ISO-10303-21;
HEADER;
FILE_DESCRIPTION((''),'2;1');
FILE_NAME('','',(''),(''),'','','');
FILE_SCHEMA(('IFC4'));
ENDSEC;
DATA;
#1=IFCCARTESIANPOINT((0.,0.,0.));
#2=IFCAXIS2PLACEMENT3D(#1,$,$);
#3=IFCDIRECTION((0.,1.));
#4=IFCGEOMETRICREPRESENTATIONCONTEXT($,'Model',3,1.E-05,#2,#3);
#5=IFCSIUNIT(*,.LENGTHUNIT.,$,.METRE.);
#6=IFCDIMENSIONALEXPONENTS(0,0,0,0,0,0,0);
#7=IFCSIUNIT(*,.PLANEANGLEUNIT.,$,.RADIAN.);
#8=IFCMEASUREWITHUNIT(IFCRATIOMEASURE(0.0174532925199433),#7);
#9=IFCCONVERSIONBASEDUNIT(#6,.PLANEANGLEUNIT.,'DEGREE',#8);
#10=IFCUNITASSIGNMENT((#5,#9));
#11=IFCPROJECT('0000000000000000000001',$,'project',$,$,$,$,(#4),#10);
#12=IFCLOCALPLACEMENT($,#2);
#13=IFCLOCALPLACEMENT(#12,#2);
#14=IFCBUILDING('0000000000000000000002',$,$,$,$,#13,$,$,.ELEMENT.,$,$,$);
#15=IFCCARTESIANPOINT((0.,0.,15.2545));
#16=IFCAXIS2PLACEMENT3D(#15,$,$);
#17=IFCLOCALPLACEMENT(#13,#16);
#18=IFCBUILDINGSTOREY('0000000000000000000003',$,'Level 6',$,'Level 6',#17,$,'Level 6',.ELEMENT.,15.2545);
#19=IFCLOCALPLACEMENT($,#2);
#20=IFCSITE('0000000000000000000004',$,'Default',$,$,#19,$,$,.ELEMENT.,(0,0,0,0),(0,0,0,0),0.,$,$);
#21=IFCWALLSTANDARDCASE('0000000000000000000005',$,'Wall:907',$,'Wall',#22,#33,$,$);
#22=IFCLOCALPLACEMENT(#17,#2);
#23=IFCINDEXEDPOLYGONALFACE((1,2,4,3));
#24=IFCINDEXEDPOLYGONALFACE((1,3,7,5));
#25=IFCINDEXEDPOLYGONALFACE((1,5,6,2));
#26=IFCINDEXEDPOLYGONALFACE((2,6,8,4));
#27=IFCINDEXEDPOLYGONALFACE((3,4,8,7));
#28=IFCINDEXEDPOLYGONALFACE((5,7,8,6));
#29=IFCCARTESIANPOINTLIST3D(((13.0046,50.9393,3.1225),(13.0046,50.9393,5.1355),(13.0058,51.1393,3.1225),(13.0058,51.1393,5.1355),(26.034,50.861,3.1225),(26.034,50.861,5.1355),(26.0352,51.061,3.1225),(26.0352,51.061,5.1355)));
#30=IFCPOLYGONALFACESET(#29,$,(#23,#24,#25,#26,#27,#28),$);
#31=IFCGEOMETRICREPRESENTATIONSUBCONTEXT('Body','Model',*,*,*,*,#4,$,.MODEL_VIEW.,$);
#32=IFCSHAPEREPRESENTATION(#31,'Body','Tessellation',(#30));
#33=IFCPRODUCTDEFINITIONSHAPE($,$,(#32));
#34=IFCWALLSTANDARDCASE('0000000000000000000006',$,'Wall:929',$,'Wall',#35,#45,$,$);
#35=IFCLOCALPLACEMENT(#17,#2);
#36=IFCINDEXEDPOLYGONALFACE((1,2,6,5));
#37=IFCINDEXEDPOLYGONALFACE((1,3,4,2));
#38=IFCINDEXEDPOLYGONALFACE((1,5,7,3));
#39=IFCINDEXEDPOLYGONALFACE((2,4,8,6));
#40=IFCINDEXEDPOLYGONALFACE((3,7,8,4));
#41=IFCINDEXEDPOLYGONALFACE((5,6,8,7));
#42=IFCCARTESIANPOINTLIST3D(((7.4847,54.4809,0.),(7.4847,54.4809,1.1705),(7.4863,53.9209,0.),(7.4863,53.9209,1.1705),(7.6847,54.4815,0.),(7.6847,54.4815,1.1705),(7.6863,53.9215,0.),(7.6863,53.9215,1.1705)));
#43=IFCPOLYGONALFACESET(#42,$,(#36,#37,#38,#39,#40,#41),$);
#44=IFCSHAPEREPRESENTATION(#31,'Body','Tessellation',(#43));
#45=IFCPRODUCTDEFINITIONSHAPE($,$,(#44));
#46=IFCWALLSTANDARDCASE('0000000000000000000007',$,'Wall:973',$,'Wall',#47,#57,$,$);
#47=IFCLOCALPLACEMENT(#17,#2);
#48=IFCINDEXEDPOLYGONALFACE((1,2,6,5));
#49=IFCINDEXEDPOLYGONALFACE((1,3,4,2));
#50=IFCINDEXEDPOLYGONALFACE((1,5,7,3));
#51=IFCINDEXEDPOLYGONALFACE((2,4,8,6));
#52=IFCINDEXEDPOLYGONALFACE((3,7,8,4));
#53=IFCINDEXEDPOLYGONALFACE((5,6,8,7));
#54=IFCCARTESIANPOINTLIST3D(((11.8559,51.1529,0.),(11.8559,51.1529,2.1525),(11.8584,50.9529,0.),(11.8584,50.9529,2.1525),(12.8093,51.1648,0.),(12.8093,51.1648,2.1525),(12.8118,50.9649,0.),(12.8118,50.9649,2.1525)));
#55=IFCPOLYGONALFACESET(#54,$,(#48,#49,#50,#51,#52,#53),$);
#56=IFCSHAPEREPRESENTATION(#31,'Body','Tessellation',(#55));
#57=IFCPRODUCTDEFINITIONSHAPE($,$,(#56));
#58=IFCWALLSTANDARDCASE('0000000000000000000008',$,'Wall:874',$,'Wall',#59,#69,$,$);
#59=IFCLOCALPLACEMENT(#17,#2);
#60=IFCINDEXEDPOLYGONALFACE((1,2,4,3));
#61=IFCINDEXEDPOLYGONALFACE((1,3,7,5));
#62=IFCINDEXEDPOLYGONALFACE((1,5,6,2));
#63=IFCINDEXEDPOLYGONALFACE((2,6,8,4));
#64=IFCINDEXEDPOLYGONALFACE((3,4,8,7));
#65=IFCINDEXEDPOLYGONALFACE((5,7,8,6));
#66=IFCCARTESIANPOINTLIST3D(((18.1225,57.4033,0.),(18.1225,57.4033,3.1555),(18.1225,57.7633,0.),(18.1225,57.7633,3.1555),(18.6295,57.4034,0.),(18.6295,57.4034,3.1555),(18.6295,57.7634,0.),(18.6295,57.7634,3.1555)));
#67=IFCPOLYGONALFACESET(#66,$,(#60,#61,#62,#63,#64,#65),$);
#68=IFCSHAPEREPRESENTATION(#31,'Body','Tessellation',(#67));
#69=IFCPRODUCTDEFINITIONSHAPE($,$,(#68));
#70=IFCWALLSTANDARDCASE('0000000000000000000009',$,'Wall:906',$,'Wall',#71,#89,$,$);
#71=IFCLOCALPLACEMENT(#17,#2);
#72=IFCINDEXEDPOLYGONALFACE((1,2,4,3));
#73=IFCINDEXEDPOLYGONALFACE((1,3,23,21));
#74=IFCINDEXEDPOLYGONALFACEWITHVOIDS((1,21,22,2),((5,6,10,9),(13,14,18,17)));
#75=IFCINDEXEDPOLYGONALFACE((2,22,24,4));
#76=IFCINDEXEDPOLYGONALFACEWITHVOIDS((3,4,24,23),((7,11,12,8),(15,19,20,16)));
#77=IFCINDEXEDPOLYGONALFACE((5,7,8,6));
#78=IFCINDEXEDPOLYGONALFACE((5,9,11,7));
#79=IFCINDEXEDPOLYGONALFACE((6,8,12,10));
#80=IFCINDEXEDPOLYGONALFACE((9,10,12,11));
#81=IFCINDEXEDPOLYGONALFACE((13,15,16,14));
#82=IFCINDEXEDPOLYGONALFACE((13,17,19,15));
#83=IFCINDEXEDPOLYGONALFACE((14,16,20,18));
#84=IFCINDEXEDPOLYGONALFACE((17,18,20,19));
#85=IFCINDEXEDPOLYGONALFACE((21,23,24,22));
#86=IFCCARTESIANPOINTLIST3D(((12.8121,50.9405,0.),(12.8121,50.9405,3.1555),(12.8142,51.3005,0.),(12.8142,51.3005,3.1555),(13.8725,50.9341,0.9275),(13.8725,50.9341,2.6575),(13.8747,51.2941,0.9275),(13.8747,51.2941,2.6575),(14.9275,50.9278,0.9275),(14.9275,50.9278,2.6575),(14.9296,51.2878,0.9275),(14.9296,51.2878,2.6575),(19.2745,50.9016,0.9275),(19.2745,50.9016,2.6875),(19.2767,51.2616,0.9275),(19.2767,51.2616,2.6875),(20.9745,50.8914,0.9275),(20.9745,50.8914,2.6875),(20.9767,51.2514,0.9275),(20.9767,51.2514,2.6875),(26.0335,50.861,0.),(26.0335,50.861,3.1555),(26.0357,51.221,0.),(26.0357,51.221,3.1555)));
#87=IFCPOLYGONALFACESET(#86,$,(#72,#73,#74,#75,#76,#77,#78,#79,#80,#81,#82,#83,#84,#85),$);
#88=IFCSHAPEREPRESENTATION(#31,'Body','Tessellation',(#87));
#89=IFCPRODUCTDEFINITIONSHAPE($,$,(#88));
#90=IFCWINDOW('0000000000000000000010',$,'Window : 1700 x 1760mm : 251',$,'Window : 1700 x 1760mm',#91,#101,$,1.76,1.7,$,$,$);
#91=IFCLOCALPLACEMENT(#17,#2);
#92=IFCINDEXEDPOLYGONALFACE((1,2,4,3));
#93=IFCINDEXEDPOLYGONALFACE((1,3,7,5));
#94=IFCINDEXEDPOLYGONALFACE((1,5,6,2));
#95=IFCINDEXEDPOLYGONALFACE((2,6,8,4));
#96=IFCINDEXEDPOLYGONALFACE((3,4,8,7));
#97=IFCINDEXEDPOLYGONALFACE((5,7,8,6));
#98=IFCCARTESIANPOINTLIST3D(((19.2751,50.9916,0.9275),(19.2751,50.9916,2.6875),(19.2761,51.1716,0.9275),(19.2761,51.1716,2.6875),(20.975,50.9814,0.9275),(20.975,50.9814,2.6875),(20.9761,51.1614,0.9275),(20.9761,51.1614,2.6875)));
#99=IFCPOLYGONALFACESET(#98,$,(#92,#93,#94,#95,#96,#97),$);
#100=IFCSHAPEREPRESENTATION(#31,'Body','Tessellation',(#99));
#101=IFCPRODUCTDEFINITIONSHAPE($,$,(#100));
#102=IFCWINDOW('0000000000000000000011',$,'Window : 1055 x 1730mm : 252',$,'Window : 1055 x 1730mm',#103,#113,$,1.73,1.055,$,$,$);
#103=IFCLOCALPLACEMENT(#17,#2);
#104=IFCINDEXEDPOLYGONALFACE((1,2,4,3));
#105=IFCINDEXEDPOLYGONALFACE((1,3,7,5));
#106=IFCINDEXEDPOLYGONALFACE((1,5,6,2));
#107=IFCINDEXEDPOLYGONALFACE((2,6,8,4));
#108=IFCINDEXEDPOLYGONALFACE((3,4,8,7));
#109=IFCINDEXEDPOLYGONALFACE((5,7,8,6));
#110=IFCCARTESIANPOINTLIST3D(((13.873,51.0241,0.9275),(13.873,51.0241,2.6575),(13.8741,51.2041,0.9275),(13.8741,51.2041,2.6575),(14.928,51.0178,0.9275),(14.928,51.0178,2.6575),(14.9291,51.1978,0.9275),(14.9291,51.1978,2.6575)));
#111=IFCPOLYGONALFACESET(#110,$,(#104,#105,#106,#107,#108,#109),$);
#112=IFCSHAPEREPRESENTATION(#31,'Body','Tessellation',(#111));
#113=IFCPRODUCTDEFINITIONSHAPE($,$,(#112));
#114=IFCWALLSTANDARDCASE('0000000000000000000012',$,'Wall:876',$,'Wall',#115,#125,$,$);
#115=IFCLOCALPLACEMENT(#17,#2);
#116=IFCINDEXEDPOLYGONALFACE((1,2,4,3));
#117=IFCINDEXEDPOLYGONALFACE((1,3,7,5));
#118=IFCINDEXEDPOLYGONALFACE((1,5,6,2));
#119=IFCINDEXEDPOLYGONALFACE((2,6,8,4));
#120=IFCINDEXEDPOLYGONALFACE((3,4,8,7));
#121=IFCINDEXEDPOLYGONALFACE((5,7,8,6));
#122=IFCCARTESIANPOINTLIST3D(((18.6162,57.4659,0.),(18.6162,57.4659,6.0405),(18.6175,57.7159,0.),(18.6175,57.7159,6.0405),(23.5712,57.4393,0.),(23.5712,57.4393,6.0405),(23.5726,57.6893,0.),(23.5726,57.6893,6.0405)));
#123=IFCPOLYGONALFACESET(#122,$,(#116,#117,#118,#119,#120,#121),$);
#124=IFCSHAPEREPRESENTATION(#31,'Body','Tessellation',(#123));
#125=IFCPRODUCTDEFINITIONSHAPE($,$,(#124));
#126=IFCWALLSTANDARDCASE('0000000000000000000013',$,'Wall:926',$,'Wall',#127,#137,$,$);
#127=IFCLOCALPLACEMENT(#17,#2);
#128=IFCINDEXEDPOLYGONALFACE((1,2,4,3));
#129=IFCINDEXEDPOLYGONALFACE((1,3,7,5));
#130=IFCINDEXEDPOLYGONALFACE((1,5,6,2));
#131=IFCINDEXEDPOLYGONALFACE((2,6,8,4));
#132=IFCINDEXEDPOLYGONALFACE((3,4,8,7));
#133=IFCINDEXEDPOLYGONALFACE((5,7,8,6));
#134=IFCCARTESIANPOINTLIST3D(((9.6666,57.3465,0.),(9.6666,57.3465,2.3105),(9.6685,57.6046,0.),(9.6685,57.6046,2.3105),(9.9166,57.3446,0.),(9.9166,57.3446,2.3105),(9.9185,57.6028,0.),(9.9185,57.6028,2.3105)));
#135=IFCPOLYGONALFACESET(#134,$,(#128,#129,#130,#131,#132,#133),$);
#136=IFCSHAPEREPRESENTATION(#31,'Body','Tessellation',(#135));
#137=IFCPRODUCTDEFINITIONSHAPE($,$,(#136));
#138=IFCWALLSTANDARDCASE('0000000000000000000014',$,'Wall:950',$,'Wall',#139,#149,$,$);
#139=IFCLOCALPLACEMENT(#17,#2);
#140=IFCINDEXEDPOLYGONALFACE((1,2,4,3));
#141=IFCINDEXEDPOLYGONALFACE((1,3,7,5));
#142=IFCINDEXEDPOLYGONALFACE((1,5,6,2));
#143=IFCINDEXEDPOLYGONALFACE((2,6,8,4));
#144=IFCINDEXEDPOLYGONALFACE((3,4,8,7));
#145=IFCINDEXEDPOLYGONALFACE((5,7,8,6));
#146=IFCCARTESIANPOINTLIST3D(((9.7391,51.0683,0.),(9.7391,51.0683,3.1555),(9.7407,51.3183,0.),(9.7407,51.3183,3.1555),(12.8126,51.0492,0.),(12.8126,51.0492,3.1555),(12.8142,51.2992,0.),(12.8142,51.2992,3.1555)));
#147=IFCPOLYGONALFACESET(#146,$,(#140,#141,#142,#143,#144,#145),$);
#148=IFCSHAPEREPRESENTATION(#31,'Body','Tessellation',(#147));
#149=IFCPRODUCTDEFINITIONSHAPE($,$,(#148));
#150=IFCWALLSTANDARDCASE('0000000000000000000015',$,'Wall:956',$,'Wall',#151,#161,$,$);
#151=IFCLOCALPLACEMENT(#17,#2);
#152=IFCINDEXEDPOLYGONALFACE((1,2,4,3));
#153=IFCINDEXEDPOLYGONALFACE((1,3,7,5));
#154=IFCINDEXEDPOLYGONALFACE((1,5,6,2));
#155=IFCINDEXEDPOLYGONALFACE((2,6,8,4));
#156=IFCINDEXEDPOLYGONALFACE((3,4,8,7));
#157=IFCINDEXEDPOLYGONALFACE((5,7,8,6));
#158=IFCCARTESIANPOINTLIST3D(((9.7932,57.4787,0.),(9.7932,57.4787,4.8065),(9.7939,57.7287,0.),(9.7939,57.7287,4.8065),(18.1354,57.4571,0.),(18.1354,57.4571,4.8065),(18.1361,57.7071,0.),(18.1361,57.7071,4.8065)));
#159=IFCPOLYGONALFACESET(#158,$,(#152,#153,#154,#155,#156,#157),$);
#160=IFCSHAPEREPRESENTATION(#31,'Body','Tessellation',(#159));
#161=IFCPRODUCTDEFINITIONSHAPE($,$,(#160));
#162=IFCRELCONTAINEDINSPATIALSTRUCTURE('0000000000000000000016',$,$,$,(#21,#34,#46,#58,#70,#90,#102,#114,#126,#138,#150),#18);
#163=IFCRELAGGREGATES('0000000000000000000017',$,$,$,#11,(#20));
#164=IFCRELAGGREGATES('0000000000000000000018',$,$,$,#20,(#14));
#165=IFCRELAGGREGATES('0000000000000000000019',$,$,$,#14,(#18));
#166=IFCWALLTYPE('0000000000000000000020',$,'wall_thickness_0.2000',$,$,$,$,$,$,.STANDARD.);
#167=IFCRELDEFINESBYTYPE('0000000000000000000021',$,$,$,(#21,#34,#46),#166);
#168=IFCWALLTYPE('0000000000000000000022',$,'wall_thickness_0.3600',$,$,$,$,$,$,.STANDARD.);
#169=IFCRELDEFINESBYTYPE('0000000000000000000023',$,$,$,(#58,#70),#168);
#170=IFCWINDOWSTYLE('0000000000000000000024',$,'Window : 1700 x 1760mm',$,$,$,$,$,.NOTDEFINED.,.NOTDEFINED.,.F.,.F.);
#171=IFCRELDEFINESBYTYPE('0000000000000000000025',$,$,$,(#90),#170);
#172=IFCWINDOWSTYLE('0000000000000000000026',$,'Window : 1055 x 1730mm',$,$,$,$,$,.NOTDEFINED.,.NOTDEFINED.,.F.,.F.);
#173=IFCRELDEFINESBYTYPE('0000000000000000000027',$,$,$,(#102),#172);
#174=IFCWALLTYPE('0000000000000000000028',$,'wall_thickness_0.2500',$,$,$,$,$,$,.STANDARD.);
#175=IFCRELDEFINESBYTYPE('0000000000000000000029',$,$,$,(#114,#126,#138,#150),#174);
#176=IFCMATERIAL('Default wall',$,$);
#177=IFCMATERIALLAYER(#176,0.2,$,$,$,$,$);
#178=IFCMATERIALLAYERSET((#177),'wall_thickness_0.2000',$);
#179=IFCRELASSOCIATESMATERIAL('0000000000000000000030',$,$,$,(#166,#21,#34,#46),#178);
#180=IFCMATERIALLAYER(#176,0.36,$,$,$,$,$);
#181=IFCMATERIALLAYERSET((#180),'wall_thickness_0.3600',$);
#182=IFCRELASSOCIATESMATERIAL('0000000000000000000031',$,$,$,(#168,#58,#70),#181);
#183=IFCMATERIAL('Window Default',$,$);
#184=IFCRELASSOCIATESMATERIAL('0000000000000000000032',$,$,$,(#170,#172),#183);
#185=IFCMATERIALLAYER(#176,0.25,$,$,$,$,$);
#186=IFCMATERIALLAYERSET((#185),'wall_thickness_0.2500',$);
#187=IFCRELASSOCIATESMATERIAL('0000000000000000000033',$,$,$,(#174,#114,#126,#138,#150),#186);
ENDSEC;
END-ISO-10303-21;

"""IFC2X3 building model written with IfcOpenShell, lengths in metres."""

from ifc_helpers import new_model, entity, si_unit, converted_unit, direction, frame, frame_2d, origin, origin_2d_with_axis, place, context, subcontext, project, spatial, polyline, rectangle, outline, extrude, source, transform, mapped, material, layer, layer_set, layer_usage, type_object, type_shapes, element, fill, save


model = new_model("IFC2X3")

# Units and contexts
model_context = context("Model", 3, precision=1e-05, world=origin(), true_north=direction((0.0, 1.0)))
body_context = subcontext(model_context, "Body", "Model", "MODEL_VIEW")
ifc_project = project(units=[si_unit("LENGTHUNIT", "METRE"), converted_unit("PLANEANGLEUNIT", "DEGREE", entity("IfcRatioMeasure", 0.0174532925199433), si_unit("PLANEANGLEUNIT", "RADIAN"), dimensions=[0, 0, 0, 0, 0, 0, 0])], contexts=[model_context])

# Site, building, storey
site_placement = place(None, origin())
site = spatial("IfcSite", under=ifc_project, at=site_placement, Name="Default", CompositionType="ELEMENT", RefLatitude=(0, 0, 0, 0), RefLongitude=(0, 0, 0, 0), RefElevation=0.0)
placement_1 = place(None, origin())
building_placement = place(placement_1, origin())
building = spatial("IfcBuilding", under=site, at=building_placement, CompositionType="ELEMENT")
storey_placement = place(building_placement, frame((0.0, 0.0, 15.2545)))
storey = spatial("IfcBuildingStorey", under=building, at=storey_placement, Name="Level 6", ObjectType="Level 6", LongName="Level 6", CompositionType="ELEMENT", Elevation=15.2545)

# Shared definitions
ifc_material_1 = material(Name="Default wall")
ifc_material_2 = material(Name="Window Default")

# Walls
ifc_layer_1 = layer(ifc_material_1, 0.2)
ifc_layer_set_1 = layer_set([ifc_layer_1], Name="wall_thickness_0.2000")
ifc_layer_usage_1 = layer_usage(ifc_layer_set_1, "AXIS2", "POSITIVE", -0.1)
wall_type_1 = type_object("IfcWallType", Name="wall_thickness_0.2000", PredefinedType="STANDARD", material=ifc_layer_set_1)
placement_2 = place(building_placement, frame((0.0, 0.0, 18.377)))
wall_1_placement = place(placement_2, frame((13.0052, 51.0393, 0.0), z_axis=(0.0, 0.0, 1.0), x_axis=(0.999982, -0.006009, 0.0)))
element("IfcWallStandardCase", 1, at=wall_1_placement, inside=storey, type_object=wall_type_1, material=ifc_layer_usage_1, Name="Wall:907", ObjectType="Wall", context=body_context, shape_type="SweptSolid", body=[
    extrude(outline(polyline([(13.0296, -0.1), (13.0296, 0.1), (0.0, 0.1), (0.0, -0.1), (13.0296, -0.1)])), origin(), (0.0, 0.0, 1.0), 2.013),
])
wall_2_placement = place(storey_placement, frame((7.5863, 53.9212, 0.0), z_axis=(0.0, 0.0, 1.0), x_axis=(-0.002904, 0.999996, 0.0)))
element("IfcWallStandardCase", 2, at=wall_2_placement, inside=storey, type_object=wall_type_1, material=ifc_layer_usage_1, Name="Wall:929", ObjectType="Wall", context=body_context, shape_type="SweptSolid", body=[
    extrude(outline(polyline([(0.56, -0.1), (0.56, 0.1), (0.0, 0.1), (0.0, -0.1), (0.56, -0.1)])), origin(), (0.0, 0.0, 1.0), 1.1705),
])
wall_3_placement = place(storey_placement, frame((12.8105, 51.0648, 0.0), z_axis=(0.0, 0.0, 1.0), x_axis=(-0.999922, -0.012511, 0.0)))
element("IfcWallStandardCase", 3, at=wall_3_placement, inside=storey, type_object=wall_type_1, material=ifc_layer_usage_1, Name="Wall:973", ObjectType="Wall", context=body_context, shape_type="SweptSolid", body=[
    extrude(outline(polyline([(0.9534, -0.1), (0.9534, 0.1), (0.0, 0.1), (0.0, -0.1), (0.9534, -0.1)])), origin(), (0.0, 0.0, 1.0), 2.1525),
])
ifc_layer_2 = layer(ifc_material_1, 0.36)
ifc_layer_set_2 = layer_set([ifc_layer_2], Name="wall_thickness_0.3600")
ifc_layer_usage_2 = layer_usage(ifc_layer_set_2, "AXIS2", "POSITIVE", -0.18)
wall_type_2 = type_object("IfcWallType", Name="wall_thickness_0.3600", PredefinedType="STANDARD", material=ifc_layer_set_2)
wall_4_placement = place(storey_placement, frame((18.1225, 57.5833, 0.0), z_axis=(0.0, 0.0, 1.0), x_axis=(1.0, 0.000075, 0.0)))
element("IfcWallStandardCase", 4, at=wall_4_placement, inside=storey, type_object=wall_type_2, material=ifc_layer_usage_2, Name="Wall:874", ObjectType="Wall", context=body_context, shape_type="SweptSolid", body=[
    extrude(outline(polyline([(0.507, -0.18), (0.507, 0.18), (0.0, 0.18), (0.0, -0.18), (0.507, -0.18)])), origin(), (0.0, 0.0, 1.0), 3.1555),
])

# Wall, openings, windows
wall_5_placement = place(storey_placement, frame((12.8132, 51.1205, 0.0), z_axis=(0.0, 0.0, 1.0), x_axis=(0.999982, -0.006009, 0.0)))
wall_5 = element("IfcWallStandardCase", 5, at=wall_5_placement, inside=storey, type_object=wall_type_2, material=ifc_layer_usage_2, Name="Wall:906", ObjectType="Wall", context=body_context, shape_type="SweptSolid", body=[
    extrude(outline(polyline([(13.2216, -0.18), (13.2216, 0.18), (0.0, 0.18), (0.0, -0.18), (13.2216, -0.18)])), origin(), (0.0, 0.0, 1.0), 3.1555),
])
opening_1_placement = place(wall_5_placement, frame((6.4626, -0.18, 0.9275)))
opening_1 = element("IfcOpeningElement", 6, at=opening_1_placement, cuts=wall_5, ObjectType="Opening", context=body_context, shape_type="SweptSolid", body=[
    extrude(rectangle(XDim=1.7, YDim=1.76, at=frame_2d((0.88, 0.85), x_axis=(0.0, 1.0))), frame((0.0, 0.0, 0.0), z_axis=(0.0, 1.0, 0.0), x_axis=(0.0, 0.0, 1.0)), (0.0, 0.0, 1.0), 0.36),
])
opening_2_placement = place(wall_5_placement, frame((1.0604, -0.18, 0.9275)))
opening_2 = element("IfcOpeningElement", 7, at=opening_2_placement, cuts=wall_5, ObjectType="Opening", context=body_context, shape_type="SweptSolid", body=[
    extrude(rectangle(XDim=1.055, YDim=1.73, at=frame_2d((0.865, 0.5275), x_axis=(0.0, 1.0))), frame((0.0, 0.0, 0.0), z_axis=(0.0, 1.0, 0.0), x_axis=(0.0, 0.0, 1.0)), (0.0, 0.0, 1.0), 0.36),
])
window_style_1 = type_object("IfcWindowStyle", Name="Window : 1700 x 1760mm", ConstructionType="NOTDEFINED", OperationType="NOTDEFINED", ParameterTakesPrecedence=False, Sizeable=False, material=ifc_material_2)
shared_shape_1 = source(origin(), body_context, "Body", "SweptSolid", [
    extrude(rectangle(XDim=0.18, YDim=1.7, at=origin_2d_with_axis()), frame((0.85, 0.18, 0.0), z_axis=(0.0, 0.0, 1.0), x_axis=(0.0, 1.0, 0.0)), (0.0, 0.0, 1.0), 1.76),
])
type_shapes(window_style_1, [shared_shape_1])
window_1_placement = place(opening_1_placement, origin())
window_1 = element("IfcWindow", 8, at=window_1_placement, inside=storey, type_object=window_style_1, Name="Window : 1700 x 1760mm : 251", ObjectType="Window : 1700 x 1760mm", OverallHeight=1.76, OverallWidth=1.7, context=body_context, shape_type="MappedRepresentation", body=[
    mapped(shared_shape_1, transform((0.0, 0.0, 0.0), scale=1.0)),
])
fill(opening_1, window_1)
window_style_2 = type_object("IfcWindowStyle", Name="Window : 1055 x 1730mm", ConstructionType="NOTDEFINED", OperationType="NOTDEFINED", ParameterTakesPrecedence=False, Sizeable=False, material=ifc_material_2)
shared_shape_2 = source(origin(), body_context, "Body", "SweptSolid", [
    extrude(rectangle(XDim=0.18, YDim=1.055, at=origin_2d_with_axis()), frame((0.5275, 0.18, 0.0), z_axis=(0.0, 0.0, 1.0), x_axis=(0.0, 1.0, 0.0)), (0.0, 0.0, 1.0), 1.73),
])
type_shapes(window_style_2, [shared_shape_2])
window_2_placement = place(opening_2_placement, origin())
window_2 = element("IfcWindow", 9, at=window_2_placement, inside=storey, type_object=window_style_2, Name="Window : 1055 x 1730mm : 252", ObjectType="Window : 1055 x 1730mm", OverallHeight=1.73, OverallWidth=1.055, context=body_context, shape_type="MappedRepresentation", body=[
    mapped(shared_shape_2, transform((0.0, 0.0, 0.0), scale=1.0)),
])
fill(opening_2, window_2)

# Walls
ifc_layer_3 = layer(ifc_material_1, 0.25)
ifc_layer_set_3 = layer_set([ifc_layer_3], Name="wall_thickness_0.2500")
ifc_layer_usage_3 = layer_usage(ifc_layer_set_3, "AXIS2", "POSITIVE", -0.125)
wall_type_3 = type_object("IfcWallType", Name="wall_thickness_0.2500", PredefinedType="STANDARD", material=ifc_layer_set_3)
wall_6_placement = place(storey_placement, frame((18.6168, 57.5909, 0.0), z_axis=(0.0, 0.0, 1.0), x_axis=(0.999986, -0.005371, 0.0)))
element("IfcWallStandardCase", 10, at=wall_6_placement, inside=storey, type_object=wall_type_3, material=ifc_layer_usage_3, Name="Wall:876", ObjectType="Wall", context=body_context, shape_type="SweptSolid", body=[
    extrude(outline(polyline([(4.9551, -0.125), (4.9551, 0.125), (0.0, 0.125), (0.0, -0.125), (4.9551, -0.125)])), origin(), (0.0, 0.0, 1.0), 6.0405),
])
wall_7_placement = place(storey_placement, frame((9.7935, 57.6037, 0.0), z_axis=(0.0, 0.0, 1.0), x_axis=(-0.007478, -0.999972, 0.0)))
element("IfcWallStandardCase", 11, at=wall_7_placement, inside=storey, type_object=wall_type_3, material=ifc_layer_usage_3, Name="Wall:926", ObjectType="Wall", context=body_context, shape_type="SweptSolid", body=[
    extrude(outline(polyline([(0.2581, -0.125), (0.2581, 0.125), (0.0, 0.125), (0.0, -0.125), (0.2581, -0.125)])), origin(), (0.0, 0.0, 1.0), 2.3105),
])
wall_8_placement = place(storey_placement, frame((9.7399, 51.1933, 0.0), z_axis=(0.0, 0.0, 1.0), x_axis=(0.999981, -0.006219, 0.0)))
element("IfcWallStandardCase", 12, at=wall_8_placement, inside=storey, type_object=wall_type_3, material=ifc_layer_usage_3, Name="Wall:950", ObjectType="Wall", context=body_context, shape_type="SweptSolid", body=[
    extrude(outline(polyline([(3.0735, -0.125), (3.0735, 0.125), (0.0, 0.125), (0.0, -0.125), (3.0735, -0.125)])), origin(), (0.0, 0.0, 1.0), 3.1555),
])
wall_9_placement = place(storey_placement, frame((9.7935, 57.6037, 0.0), z_axis=(0.0, 0.0, 1.0), x_axis=(0.999997, -0.002586, 0.0)))
element("IfcWallStandardCase", 13, at=wall_9_placement, inside=storey, type_object=wall_type_3, material=ifc_layer_usage_3, Name="Wall:956", ObjectType="Wall", context=body_context, shape_type="SweptSolid", body=[
    extrude(outline(polyline([(8.3423, -0.125), (8.3423, 0.125), (0.0, 0.125), (0.0, -0.125), (8.3423, -0.125)])), origin(), (0.0, 0.0, 1.0), 4.8065),
])

save(model, "model.ifc")
